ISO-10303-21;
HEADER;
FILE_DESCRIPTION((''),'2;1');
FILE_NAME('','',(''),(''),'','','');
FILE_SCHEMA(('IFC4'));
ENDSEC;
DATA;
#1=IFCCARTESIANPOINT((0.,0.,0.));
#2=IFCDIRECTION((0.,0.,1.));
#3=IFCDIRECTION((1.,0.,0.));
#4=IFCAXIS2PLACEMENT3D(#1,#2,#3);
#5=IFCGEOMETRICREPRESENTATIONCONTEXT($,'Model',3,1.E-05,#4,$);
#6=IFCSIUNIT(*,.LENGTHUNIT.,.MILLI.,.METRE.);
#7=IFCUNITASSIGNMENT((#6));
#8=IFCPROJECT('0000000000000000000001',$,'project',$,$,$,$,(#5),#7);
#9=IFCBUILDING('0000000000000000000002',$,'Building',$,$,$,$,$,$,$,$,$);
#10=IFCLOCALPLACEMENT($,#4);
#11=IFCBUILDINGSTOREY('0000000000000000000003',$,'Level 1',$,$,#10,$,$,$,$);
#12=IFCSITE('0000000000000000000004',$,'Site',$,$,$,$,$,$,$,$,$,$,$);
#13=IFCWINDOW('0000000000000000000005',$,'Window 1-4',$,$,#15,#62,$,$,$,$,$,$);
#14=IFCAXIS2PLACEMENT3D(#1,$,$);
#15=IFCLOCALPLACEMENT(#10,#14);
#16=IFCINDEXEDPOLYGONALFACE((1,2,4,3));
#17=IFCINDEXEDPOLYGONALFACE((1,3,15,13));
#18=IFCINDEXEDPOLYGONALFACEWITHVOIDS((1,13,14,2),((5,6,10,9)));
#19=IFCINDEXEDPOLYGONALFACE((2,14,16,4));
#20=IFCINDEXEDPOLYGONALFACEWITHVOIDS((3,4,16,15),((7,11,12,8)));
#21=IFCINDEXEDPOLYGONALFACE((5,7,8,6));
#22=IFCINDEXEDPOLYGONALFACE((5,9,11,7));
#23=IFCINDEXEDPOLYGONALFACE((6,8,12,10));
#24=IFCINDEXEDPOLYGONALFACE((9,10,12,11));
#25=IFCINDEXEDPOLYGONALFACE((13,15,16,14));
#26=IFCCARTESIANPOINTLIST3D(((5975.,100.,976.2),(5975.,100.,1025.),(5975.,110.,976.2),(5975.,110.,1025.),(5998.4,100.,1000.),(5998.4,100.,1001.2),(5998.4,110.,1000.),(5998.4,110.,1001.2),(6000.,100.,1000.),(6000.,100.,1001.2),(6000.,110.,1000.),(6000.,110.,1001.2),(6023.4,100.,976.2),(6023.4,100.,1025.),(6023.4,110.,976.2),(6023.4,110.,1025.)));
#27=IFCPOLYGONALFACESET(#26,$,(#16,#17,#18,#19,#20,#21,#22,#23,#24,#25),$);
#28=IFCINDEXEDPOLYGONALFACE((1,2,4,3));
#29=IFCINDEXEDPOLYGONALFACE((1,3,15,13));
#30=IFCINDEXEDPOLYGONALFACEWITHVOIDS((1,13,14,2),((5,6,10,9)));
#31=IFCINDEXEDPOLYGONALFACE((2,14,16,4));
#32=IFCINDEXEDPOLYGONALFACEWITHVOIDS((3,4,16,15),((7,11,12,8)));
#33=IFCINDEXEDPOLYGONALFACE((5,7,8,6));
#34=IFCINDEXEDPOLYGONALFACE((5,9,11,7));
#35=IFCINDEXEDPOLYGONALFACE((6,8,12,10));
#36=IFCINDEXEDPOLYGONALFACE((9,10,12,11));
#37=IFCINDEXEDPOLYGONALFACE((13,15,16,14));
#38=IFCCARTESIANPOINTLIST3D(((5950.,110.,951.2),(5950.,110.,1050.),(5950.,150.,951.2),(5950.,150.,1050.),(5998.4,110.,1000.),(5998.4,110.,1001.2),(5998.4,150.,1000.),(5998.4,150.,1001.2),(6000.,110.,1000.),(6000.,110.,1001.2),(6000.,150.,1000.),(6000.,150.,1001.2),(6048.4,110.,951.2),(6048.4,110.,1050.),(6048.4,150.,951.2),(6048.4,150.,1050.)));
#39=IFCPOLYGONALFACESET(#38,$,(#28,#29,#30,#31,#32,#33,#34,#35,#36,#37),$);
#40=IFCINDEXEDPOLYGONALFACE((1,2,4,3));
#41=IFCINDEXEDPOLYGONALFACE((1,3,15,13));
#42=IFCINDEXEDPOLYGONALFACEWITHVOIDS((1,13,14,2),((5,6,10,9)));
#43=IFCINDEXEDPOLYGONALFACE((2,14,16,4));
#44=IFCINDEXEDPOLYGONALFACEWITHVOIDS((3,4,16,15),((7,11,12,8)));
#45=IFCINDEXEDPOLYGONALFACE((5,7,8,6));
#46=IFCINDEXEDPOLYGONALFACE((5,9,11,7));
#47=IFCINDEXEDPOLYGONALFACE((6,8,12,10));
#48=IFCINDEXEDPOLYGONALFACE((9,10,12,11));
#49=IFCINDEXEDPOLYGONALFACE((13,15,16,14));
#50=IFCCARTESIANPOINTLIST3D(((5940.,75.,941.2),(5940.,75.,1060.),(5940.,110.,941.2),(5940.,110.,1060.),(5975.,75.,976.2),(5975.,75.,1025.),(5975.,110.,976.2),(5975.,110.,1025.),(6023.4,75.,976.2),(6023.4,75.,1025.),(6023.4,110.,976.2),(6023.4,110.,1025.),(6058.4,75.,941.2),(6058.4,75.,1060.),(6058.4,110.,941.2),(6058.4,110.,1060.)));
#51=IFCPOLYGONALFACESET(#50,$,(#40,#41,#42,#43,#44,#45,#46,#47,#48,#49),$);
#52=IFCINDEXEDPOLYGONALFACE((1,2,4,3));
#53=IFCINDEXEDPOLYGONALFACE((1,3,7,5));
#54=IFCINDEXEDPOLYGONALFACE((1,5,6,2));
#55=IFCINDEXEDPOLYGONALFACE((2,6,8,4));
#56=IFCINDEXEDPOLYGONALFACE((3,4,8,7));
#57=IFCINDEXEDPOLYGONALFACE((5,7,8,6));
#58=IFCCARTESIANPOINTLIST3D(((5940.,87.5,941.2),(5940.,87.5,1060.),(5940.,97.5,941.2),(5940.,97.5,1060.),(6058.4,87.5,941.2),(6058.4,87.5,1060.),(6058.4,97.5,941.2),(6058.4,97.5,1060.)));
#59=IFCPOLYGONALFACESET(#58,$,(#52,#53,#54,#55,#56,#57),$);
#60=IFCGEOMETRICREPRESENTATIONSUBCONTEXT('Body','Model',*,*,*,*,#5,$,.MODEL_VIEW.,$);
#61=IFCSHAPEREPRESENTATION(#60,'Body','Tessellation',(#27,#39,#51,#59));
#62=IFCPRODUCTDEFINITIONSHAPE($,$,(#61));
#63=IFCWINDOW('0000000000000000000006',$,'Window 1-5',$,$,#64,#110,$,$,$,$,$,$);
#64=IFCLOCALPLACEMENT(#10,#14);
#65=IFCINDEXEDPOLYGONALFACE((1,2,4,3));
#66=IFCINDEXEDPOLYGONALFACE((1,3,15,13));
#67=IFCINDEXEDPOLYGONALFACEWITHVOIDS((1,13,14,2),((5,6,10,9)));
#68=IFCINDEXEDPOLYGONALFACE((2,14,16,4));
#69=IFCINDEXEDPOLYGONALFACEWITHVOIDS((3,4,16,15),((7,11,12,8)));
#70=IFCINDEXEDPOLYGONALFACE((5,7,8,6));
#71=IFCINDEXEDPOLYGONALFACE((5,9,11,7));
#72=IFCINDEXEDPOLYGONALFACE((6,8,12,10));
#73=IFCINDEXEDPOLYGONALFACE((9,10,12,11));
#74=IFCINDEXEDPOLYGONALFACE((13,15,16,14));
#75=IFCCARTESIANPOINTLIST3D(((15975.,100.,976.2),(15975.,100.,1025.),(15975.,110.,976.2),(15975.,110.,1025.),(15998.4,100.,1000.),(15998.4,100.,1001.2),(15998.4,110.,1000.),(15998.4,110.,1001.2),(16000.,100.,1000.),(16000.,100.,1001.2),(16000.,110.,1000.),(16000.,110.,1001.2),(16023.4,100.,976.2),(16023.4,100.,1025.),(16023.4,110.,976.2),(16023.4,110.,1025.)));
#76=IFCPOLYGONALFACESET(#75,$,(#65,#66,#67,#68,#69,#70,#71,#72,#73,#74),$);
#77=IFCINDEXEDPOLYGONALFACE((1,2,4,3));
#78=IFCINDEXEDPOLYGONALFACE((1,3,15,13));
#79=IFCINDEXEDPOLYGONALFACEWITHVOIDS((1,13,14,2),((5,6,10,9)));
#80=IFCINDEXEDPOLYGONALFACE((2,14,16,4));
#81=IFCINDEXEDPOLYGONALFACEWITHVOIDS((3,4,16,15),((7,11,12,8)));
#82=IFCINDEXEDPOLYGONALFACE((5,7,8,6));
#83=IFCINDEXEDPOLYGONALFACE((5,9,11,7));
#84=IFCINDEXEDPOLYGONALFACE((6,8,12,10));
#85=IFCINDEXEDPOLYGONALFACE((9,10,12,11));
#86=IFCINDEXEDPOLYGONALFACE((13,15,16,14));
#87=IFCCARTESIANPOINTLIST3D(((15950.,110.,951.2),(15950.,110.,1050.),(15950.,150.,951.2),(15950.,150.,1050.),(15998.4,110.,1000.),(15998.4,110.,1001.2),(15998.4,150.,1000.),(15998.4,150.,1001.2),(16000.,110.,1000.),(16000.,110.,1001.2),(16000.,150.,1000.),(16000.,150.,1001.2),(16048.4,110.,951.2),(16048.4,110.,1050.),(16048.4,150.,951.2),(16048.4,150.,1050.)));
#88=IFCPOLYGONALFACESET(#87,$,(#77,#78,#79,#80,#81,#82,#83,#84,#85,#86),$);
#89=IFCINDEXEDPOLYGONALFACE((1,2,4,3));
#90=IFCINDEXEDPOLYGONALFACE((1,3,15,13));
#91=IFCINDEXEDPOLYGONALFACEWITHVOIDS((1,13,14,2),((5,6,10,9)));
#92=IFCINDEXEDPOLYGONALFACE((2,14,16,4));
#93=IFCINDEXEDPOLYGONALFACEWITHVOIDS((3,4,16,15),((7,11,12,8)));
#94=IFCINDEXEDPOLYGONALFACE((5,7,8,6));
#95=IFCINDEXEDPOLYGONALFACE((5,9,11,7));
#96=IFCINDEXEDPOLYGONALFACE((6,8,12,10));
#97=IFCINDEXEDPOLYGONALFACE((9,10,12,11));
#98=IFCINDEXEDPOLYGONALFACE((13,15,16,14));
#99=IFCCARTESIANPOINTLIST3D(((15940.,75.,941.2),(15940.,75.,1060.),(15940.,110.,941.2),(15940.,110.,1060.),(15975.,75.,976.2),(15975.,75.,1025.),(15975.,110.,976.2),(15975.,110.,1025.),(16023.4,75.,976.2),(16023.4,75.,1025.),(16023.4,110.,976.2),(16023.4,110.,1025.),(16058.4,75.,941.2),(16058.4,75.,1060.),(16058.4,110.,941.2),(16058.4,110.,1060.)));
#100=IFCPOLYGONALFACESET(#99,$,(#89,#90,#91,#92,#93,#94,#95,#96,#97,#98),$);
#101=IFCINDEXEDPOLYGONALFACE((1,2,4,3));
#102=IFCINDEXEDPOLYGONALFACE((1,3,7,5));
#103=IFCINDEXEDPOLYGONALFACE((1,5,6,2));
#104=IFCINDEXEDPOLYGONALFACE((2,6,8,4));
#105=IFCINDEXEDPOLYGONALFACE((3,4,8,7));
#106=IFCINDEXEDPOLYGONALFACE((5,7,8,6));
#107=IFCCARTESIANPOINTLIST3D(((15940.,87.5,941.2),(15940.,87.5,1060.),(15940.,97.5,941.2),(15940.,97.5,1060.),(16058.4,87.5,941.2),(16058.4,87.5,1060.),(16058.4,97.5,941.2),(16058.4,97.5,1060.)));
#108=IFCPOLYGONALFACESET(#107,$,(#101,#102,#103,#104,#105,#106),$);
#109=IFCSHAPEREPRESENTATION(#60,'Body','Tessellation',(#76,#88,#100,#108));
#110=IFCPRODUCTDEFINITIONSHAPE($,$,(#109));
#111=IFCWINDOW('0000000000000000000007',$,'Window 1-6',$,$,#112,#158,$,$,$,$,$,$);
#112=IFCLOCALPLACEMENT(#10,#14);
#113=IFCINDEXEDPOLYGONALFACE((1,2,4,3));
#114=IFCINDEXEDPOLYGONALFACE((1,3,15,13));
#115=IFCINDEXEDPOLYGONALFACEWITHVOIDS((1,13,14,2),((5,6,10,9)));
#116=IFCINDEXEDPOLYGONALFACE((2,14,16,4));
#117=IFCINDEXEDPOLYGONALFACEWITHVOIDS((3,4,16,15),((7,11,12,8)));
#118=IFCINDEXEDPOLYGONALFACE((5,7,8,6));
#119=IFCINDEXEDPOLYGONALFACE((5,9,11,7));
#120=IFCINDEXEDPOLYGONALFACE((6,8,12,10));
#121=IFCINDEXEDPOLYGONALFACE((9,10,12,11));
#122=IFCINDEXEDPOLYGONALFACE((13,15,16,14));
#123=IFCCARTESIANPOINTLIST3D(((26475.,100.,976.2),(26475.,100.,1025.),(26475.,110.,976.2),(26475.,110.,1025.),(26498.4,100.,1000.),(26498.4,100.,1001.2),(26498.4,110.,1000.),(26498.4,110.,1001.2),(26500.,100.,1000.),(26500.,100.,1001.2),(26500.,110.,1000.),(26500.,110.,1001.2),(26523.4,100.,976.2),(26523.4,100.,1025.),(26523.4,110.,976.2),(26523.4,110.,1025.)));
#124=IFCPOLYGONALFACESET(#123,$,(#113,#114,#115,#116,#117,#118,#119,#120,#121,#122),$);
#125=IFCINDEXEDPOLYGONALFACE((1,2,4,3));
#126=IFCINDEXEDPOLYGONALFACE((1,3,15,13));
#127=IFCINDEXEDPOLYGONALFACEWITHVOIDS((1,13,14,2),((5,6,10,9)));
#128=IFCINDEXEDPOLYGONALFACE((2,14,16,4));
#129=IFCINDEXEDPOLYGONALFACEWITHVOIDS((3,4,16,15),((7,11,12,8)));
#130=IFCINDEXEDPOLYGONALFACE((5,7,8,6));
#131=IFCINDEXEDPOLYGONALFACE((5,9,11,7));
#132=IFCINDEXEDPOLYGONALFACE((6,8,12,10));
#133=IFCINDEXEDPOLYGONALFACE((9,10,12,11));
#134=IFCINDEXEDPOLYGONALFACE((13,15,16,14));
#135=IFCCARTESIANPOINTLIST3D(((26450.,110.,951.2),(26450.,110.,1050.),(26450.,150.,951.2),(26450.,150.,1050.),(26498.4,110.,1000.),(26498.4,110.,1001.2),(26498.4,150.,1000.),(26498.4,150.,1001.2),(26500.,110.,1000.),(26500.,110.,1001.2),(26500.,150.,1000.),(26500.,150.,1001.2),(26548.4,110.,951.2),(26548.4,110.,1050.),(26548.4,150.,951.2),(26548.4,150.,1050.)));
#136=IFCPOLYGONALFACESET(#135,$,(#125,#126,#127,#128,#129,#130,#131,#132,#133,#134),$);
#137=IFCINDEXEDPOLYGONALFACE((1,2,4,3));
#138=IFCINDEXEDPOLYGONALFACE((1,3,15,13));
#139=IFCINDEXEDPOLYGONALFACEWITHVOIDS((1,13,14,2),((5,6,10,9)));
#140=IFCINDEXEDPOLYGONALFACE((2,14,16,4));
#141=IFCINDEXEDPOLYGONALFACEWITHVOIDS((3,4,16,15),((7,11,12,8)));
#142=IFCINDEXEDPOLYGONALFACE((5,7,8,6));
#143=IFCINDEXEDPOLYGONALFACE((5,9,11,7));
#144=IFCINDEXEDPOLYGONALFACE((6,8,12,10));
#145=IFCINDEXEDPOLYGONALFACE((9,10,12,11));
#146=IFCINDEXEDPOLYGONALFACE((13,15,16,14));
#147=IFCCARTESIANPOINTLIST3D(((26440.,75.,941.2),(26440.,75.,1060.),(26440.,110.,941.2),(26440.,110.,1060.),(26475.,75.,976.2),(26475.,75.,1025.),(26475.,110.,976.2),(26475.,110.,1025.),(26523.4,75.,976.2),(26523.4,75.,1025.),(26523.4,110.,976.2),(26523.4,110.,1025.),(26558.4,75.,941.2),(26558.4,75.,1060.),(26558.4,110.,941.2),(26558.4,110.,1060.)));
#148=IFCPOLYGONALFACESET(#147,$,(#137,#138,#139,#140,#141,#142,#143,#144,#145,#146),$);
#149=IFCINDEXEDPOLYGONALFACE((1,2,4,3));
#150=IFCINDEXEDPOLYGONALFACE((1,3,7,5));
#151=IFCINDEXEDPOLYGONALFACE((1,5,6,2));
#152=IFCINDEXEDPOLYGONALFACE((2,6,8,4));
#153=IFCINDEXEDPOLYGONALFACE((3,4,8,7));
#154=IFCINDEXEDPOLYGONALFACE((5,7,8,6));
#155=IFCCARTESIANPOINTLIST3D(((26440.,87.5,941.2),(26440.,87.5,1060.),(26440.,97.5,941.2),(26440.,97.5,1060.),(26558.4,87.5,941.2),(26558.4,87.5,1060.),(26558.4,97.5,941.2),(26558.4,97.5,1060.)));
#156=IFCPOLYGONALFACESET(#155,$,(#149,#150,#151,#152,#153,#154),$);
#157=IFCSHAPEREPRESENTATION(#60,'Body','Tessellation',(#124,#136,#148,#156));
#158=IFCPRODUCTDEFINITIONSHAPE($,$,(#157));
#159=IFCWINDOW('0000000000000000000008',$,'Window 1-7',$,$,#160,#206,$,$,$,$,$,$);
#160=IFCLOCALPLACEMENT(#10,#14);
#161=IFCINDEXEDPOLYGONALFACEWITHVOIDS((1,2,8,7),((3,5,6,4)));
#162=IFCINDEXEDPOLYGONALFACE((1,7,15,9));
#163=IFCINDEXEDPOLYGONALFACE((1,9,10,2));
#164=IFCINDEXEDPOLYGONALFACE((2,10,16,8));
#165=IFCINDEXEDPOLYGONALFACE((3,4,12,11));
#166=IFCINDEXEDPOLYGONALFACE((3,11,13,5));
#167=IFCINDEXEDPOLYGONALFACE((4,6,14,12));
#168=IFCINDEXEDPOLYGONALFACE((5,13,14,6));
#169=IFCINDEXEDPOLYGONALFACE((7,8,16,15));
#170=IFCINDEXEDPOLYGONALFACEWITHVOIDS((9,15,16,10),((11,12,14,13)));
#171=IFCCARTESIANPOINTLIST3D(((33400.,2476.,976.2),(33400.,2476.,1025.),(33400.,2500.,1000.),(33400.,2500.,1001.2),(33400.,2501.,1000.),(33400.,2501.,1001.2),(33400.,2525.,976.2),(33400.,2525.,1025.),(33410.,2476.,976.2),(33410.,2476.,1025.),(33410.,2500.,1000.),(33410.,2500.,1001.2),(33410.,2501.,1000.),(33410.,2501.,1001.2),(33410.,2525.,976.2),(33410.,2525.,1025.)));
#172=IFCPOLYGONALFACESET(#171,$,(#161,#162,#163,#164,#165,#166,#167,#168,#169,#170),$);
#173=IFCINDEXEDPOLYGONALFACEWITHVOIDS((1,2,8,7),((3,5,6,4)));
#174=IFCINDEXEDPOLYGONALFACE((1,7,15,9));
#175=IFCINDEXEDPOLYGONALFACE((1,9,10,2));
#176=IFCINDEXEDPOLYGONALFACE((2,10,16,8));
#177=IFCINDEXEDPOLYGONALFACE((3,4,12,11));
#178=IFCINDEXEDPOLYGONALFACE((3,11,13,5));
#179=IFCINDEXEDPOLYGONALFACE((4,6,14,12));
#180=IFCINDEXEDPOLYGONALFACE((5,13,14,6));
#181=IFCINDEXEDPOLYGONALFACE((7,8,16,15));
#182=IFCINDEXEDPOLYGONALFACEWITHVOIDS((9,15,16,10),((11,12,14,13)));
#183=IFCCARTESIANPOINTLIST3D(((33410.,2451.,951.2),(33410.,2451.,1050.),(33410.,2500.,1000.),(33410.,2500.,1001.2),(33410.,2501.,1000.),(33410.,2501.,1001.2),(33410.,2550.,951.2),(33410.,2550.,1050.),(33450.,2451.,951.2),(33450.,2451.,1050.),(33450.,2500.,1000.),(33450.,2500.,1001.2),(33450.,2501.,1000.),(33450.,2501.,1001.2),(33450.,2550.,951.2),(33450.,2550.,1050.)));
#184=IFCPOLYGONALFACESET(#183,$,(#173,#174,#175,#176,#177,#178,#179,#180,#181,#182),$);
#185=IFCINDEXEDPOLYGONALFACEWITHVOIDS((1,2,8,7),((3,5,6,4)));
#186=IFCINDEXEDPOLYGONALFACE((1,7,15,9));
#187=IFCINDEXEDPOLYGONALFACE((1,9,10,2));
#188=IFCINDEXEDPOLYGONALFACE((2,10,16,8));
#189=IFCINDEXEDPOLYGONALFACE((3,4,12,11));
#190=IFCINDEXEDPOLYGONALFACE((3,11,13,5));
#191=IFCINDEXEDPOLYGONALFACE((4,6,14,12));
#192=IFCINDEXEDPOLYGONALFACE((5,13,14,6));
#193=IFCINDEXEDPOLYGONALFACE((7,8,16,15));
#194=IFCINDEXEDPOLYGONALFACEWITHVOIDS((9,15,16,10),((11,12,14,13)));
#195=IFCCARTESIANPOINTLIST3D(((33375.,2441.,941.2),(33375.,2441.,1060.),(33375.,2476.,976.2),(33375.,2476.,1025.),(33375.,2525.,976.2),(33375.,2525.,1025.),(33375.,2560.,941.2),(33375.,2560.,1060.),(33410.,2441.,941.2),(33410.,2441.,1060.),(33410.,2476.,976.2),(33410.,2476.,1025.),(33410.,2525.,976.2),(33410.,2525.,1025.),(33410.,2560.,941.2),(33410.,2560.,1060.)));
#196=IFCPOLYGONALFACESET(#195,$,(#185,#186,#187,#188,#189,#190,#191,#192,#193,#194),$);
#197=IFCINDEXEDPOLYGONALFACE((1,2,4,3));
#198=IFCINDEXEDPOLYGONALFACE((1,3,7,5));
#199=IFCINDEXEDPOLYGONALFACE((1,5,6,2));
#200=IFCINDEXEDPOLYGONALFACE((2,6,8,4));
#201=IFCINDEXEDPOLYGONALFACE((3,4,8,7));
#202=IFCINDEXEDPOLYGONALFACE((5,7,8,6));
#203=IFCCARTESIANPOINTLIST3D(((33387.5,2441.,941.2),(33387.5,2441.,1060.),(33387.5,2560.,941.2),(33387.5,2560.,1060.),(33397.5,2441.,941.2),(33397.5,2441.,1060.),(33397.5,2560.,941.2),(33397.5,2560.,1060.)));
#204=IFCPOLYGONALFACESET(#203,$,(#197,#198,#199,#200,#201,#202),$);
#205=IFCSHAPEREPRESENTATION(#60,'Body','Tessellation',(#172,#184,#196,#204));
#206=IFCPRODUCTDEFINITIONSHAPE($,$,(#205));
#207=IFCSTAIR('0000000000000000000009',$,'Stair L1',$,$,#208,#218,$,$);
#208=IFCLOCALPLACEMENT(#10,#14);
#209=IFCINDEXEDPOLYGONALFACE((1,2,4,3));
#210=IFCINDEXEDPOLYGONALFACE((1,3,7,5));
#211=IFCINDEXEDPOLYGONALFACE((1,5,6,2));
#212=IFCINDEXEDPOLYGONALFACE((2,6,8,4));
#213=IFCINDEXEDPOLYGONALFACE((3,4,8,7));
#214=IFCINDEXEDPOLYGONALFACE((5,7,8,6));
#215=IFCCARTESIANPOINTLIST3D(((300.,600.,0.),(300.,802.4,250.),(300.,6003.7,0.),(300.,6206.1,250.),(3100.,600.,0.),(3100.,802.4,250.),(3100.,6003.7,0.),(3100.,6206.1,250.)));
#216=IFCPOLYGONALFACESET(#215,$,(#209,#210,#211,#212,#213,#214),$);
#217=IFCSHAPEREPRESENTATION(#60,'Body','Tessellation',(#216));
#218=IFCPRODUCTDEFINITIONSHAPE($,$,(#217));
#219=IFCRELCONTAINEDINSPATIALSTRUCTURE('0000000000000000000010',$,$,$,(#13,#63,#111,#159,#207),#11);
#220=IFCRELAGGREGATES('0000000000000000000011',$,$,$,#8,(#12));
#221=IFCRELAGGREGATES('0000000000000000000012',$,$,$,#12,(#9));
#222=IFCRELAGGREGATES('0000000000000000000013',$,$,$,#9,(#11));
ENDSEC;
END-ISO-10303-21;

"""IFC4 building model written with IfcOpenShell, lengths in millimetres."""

from ifc_helpers import new_model, si_unit, frame, origin_with_axes, place, context, subcontext, project, spatial, line, indexed_curve, outline, extrude, element, save


model = new_model("IFC4")

# Units and contexts
model_context = context("Model", 3, precision=1e-05, world=origin_with_axes())
body_context = subcontext(model_context, "Body", "Model", "MODEL_VIEW")
ifc_project = project(units=[si_unit("LENGTHUNIT", "METRE", prefix="MILLI")], contexts=[model_context])

# Site, building, storey
site = spatial("IfcSite", under=ifc_project, Name="Site")
building = spatial("IfcBuilding", under=site, Name="Building")
storey_placement = place(None, origin_with_axes())
storey = spatial("IfcBuildingStorey", under=building, at=storey_placement, Name="Level 1")

# Windows
for number, where, z_axis, x_axis, name in (
    (1, (6000.0, 200.0, 1000.0), (0.0, 0.0, 1.0), (-1.0, 0.0, 0.0), "Window 1-4"),
    (2, (16000.0, 200.0, 1000.0), (0.0, 0.0, 1.0), (-1.0, 0.0, 0.0), "Window 1-5"),
    (3, (26500.0, 200.0, 1000.0), (0.0, 0.0, 1.0), (-1.0, 0.0, 0.0), "Window 1-6"),
):
    element("IfcWindow", number, at=place(storey_placement, frame(where, z_axis=z_axis, x_axis=x_axis)), inside=storey, Name=name, context=body_context, shape_type="SweptSolid", body=[
        extrude(outline(indexed_curve([(0.0, 0.0), (1.6, 0.0), (1.6, 1.2), (0.0, 1.2)], segments=[line(1, 2, 3, 4, 1)]), holes=[indexed_curve([(25.0, 25.0), (-23.4, 25.0), (-23.4, -23.8), (25.0, -23.8)], segments=[line(1, 2, 3, 4, 1)])]), frame((0.0, 90.0, 0.0), z_axis=(0.0, -1.0, 0.0), x_axis=(1.0, 0.0, 0.0)), (0.0, 0.0, -1.0), 10.0),
        extrude(outline(indexed_curve([(0.0, 0.0), (1.6, 0.0), (1.6, 1.2), (0.0, 1.2)], segments=[line(1, 2, 3, 4, 1)]), holes=[indexed_curve([(50.0, 50.0), (-48.4, 50.0), (-48.4, -48.8), (50.0, -48.8)], segments=[line(1, 2, 3, 4, 1)])]), frame((0.0, 50.0, 0.0), z_axis=(0.0, -1.0, 0.0), x_axis=(1.0, 0.0, 0.0)), (0.0, 0.0, -1.0), 40.0),
        extrude(outline(indexed_curve([(0.0, 0.0), (-48.4, 0.0), (-48.4, -48.8), (0.0, -48.8)], segments=[line(1, 2, 3, 4, 1)]), holes=[indexed_curve([(35.0, 35.0), (-83.4, 35.0), (-83.4, -83.8), (35.0, -83.8)], segments=[line(1, 2, 3, 4, 1)])]), frame((25.0, 90.0, 25.0), z_axis=(0.0, -1.0, 0.0), x_axis=(1.0, 0.0, 0.0)), (0.0, 0.0, -1.0), 35.0),
        extrude(outline(indexed_curve([(35.0, 35.0), (-83.4, 35.0), (-83.4, -83.8), (35.0, -83.8)], segments=[line(1, 2, 3, 4, 1)])), frame((25.0, 102.5, 25.0), z_axis=(0.0, -1.0, 0.0), x_axis=(1.0, 0.0, 0.0)), (0.0, 0.0, -1.0), 10.0),
    ])
window_placement = place(storey_placement, frame((33500.0, 2500.0, 1000.0), z_axis=(0.0, 0.0, 1.0), x_axis=(0.0, 1.0, 0.0)))
element("IfcWindow", 4, at=window_placement, inside=storey, Name="Window 1-7", context=body_context, shape_type="SweptSolid", body=[
    extrude(outline(indexed_curve([(0.0, 0.0), (1.0, 0.0), (1.0, 1.2), (0.0, 1.2)], segments=[line(1, 2, 3, 4, 1)]), holes=[indexed_curve([(25.0, 25.0), (-24.0, 25.0), (-24.0, -23.8), (25.0, -23.8)], segments=[line(1, 2, 3, 4, 1)])]), frame((0.0, 90.0, 0.0), z_axis=(0.0, -1.0, 0.0), x_axis=(1.0, 0.0, 0.0)), (0.0, 0.0, -1.0), 10.0),
    extrude(outline(indexed_curve([(0.0, 0.0), (1.0, 0.0), (1.0, 1.2), (0.0, 1.2)], segments=[line(1, 2, 3, 4, 1)]), holes=[indexed_curve([(50.0, 50.0), (-49.0, 50.0), (-49.0, -48.8), (50.0, -48.8)], segments=[line(1, 2, 3, 4, 1)])]), frame((0.0, 50.0, 0.0), z_axis=(0.0, -1.0, 0.0), x_axis=(1.0, 0.0, 0.0)), (0.0, 0.0, -1.0), 40.0),
    extrude(outline(indexed_curve([(0.0, 0.0), (-49.0, 0.0), (-49.0, -48.8), (0.0, -48.8)], segments=[line(1, 2, 3, 4, 1)]), holes=[indexed_curve([(35.0, 35.0), (-84.0, 35.0), (-84.0, -83.8), (35.0, -83.8)], segments=[line(1, 2, 3, 4, 1)])]), frame((25.0, 90.0, 25.0), z_axis=(0.0, -1.0, 0.0), x_axis=(1.0, 0.0, 0.0)), (0.0, 0.0, -1.0), 35.0),
    extrude(outline(indexed_curve([(35.0, 35.0), (-84.0, 35.0), (-84.0, -83.8), (35.0, -83.8)], segments=[line(1, 2, 3, 4, 1)])), frame((25.0, 102.5, 25.0), z_axis=(0.0, -1.0, 0.0), x_axis=(1.0, 0.0, 0.0)), (0.0, 0.0, -1.0), 10.0),
])

# Stair
stair_placement = place(storey_placement, frame((300.0, 600.0, 0.0), z_axis=(0.0, 0.0, 1.0), x_axis=(1.0, 0.0, 0.0)))
element("IfcStair", 5, at=stair_placement, inside=storey, Name="Stair L1", context=body_context, shape_type="SweptSolid", body=[
    extrude(outline(indexed_curve([(0.0, 0.0), (2800.0, 0.0), (2800.0, 5403.7), (0.0, 5403.7), (0.0, 0.0)])), None, (0.0, 0.629198, 0.777245), 321.6),
])

save(model, "model.ifc")
